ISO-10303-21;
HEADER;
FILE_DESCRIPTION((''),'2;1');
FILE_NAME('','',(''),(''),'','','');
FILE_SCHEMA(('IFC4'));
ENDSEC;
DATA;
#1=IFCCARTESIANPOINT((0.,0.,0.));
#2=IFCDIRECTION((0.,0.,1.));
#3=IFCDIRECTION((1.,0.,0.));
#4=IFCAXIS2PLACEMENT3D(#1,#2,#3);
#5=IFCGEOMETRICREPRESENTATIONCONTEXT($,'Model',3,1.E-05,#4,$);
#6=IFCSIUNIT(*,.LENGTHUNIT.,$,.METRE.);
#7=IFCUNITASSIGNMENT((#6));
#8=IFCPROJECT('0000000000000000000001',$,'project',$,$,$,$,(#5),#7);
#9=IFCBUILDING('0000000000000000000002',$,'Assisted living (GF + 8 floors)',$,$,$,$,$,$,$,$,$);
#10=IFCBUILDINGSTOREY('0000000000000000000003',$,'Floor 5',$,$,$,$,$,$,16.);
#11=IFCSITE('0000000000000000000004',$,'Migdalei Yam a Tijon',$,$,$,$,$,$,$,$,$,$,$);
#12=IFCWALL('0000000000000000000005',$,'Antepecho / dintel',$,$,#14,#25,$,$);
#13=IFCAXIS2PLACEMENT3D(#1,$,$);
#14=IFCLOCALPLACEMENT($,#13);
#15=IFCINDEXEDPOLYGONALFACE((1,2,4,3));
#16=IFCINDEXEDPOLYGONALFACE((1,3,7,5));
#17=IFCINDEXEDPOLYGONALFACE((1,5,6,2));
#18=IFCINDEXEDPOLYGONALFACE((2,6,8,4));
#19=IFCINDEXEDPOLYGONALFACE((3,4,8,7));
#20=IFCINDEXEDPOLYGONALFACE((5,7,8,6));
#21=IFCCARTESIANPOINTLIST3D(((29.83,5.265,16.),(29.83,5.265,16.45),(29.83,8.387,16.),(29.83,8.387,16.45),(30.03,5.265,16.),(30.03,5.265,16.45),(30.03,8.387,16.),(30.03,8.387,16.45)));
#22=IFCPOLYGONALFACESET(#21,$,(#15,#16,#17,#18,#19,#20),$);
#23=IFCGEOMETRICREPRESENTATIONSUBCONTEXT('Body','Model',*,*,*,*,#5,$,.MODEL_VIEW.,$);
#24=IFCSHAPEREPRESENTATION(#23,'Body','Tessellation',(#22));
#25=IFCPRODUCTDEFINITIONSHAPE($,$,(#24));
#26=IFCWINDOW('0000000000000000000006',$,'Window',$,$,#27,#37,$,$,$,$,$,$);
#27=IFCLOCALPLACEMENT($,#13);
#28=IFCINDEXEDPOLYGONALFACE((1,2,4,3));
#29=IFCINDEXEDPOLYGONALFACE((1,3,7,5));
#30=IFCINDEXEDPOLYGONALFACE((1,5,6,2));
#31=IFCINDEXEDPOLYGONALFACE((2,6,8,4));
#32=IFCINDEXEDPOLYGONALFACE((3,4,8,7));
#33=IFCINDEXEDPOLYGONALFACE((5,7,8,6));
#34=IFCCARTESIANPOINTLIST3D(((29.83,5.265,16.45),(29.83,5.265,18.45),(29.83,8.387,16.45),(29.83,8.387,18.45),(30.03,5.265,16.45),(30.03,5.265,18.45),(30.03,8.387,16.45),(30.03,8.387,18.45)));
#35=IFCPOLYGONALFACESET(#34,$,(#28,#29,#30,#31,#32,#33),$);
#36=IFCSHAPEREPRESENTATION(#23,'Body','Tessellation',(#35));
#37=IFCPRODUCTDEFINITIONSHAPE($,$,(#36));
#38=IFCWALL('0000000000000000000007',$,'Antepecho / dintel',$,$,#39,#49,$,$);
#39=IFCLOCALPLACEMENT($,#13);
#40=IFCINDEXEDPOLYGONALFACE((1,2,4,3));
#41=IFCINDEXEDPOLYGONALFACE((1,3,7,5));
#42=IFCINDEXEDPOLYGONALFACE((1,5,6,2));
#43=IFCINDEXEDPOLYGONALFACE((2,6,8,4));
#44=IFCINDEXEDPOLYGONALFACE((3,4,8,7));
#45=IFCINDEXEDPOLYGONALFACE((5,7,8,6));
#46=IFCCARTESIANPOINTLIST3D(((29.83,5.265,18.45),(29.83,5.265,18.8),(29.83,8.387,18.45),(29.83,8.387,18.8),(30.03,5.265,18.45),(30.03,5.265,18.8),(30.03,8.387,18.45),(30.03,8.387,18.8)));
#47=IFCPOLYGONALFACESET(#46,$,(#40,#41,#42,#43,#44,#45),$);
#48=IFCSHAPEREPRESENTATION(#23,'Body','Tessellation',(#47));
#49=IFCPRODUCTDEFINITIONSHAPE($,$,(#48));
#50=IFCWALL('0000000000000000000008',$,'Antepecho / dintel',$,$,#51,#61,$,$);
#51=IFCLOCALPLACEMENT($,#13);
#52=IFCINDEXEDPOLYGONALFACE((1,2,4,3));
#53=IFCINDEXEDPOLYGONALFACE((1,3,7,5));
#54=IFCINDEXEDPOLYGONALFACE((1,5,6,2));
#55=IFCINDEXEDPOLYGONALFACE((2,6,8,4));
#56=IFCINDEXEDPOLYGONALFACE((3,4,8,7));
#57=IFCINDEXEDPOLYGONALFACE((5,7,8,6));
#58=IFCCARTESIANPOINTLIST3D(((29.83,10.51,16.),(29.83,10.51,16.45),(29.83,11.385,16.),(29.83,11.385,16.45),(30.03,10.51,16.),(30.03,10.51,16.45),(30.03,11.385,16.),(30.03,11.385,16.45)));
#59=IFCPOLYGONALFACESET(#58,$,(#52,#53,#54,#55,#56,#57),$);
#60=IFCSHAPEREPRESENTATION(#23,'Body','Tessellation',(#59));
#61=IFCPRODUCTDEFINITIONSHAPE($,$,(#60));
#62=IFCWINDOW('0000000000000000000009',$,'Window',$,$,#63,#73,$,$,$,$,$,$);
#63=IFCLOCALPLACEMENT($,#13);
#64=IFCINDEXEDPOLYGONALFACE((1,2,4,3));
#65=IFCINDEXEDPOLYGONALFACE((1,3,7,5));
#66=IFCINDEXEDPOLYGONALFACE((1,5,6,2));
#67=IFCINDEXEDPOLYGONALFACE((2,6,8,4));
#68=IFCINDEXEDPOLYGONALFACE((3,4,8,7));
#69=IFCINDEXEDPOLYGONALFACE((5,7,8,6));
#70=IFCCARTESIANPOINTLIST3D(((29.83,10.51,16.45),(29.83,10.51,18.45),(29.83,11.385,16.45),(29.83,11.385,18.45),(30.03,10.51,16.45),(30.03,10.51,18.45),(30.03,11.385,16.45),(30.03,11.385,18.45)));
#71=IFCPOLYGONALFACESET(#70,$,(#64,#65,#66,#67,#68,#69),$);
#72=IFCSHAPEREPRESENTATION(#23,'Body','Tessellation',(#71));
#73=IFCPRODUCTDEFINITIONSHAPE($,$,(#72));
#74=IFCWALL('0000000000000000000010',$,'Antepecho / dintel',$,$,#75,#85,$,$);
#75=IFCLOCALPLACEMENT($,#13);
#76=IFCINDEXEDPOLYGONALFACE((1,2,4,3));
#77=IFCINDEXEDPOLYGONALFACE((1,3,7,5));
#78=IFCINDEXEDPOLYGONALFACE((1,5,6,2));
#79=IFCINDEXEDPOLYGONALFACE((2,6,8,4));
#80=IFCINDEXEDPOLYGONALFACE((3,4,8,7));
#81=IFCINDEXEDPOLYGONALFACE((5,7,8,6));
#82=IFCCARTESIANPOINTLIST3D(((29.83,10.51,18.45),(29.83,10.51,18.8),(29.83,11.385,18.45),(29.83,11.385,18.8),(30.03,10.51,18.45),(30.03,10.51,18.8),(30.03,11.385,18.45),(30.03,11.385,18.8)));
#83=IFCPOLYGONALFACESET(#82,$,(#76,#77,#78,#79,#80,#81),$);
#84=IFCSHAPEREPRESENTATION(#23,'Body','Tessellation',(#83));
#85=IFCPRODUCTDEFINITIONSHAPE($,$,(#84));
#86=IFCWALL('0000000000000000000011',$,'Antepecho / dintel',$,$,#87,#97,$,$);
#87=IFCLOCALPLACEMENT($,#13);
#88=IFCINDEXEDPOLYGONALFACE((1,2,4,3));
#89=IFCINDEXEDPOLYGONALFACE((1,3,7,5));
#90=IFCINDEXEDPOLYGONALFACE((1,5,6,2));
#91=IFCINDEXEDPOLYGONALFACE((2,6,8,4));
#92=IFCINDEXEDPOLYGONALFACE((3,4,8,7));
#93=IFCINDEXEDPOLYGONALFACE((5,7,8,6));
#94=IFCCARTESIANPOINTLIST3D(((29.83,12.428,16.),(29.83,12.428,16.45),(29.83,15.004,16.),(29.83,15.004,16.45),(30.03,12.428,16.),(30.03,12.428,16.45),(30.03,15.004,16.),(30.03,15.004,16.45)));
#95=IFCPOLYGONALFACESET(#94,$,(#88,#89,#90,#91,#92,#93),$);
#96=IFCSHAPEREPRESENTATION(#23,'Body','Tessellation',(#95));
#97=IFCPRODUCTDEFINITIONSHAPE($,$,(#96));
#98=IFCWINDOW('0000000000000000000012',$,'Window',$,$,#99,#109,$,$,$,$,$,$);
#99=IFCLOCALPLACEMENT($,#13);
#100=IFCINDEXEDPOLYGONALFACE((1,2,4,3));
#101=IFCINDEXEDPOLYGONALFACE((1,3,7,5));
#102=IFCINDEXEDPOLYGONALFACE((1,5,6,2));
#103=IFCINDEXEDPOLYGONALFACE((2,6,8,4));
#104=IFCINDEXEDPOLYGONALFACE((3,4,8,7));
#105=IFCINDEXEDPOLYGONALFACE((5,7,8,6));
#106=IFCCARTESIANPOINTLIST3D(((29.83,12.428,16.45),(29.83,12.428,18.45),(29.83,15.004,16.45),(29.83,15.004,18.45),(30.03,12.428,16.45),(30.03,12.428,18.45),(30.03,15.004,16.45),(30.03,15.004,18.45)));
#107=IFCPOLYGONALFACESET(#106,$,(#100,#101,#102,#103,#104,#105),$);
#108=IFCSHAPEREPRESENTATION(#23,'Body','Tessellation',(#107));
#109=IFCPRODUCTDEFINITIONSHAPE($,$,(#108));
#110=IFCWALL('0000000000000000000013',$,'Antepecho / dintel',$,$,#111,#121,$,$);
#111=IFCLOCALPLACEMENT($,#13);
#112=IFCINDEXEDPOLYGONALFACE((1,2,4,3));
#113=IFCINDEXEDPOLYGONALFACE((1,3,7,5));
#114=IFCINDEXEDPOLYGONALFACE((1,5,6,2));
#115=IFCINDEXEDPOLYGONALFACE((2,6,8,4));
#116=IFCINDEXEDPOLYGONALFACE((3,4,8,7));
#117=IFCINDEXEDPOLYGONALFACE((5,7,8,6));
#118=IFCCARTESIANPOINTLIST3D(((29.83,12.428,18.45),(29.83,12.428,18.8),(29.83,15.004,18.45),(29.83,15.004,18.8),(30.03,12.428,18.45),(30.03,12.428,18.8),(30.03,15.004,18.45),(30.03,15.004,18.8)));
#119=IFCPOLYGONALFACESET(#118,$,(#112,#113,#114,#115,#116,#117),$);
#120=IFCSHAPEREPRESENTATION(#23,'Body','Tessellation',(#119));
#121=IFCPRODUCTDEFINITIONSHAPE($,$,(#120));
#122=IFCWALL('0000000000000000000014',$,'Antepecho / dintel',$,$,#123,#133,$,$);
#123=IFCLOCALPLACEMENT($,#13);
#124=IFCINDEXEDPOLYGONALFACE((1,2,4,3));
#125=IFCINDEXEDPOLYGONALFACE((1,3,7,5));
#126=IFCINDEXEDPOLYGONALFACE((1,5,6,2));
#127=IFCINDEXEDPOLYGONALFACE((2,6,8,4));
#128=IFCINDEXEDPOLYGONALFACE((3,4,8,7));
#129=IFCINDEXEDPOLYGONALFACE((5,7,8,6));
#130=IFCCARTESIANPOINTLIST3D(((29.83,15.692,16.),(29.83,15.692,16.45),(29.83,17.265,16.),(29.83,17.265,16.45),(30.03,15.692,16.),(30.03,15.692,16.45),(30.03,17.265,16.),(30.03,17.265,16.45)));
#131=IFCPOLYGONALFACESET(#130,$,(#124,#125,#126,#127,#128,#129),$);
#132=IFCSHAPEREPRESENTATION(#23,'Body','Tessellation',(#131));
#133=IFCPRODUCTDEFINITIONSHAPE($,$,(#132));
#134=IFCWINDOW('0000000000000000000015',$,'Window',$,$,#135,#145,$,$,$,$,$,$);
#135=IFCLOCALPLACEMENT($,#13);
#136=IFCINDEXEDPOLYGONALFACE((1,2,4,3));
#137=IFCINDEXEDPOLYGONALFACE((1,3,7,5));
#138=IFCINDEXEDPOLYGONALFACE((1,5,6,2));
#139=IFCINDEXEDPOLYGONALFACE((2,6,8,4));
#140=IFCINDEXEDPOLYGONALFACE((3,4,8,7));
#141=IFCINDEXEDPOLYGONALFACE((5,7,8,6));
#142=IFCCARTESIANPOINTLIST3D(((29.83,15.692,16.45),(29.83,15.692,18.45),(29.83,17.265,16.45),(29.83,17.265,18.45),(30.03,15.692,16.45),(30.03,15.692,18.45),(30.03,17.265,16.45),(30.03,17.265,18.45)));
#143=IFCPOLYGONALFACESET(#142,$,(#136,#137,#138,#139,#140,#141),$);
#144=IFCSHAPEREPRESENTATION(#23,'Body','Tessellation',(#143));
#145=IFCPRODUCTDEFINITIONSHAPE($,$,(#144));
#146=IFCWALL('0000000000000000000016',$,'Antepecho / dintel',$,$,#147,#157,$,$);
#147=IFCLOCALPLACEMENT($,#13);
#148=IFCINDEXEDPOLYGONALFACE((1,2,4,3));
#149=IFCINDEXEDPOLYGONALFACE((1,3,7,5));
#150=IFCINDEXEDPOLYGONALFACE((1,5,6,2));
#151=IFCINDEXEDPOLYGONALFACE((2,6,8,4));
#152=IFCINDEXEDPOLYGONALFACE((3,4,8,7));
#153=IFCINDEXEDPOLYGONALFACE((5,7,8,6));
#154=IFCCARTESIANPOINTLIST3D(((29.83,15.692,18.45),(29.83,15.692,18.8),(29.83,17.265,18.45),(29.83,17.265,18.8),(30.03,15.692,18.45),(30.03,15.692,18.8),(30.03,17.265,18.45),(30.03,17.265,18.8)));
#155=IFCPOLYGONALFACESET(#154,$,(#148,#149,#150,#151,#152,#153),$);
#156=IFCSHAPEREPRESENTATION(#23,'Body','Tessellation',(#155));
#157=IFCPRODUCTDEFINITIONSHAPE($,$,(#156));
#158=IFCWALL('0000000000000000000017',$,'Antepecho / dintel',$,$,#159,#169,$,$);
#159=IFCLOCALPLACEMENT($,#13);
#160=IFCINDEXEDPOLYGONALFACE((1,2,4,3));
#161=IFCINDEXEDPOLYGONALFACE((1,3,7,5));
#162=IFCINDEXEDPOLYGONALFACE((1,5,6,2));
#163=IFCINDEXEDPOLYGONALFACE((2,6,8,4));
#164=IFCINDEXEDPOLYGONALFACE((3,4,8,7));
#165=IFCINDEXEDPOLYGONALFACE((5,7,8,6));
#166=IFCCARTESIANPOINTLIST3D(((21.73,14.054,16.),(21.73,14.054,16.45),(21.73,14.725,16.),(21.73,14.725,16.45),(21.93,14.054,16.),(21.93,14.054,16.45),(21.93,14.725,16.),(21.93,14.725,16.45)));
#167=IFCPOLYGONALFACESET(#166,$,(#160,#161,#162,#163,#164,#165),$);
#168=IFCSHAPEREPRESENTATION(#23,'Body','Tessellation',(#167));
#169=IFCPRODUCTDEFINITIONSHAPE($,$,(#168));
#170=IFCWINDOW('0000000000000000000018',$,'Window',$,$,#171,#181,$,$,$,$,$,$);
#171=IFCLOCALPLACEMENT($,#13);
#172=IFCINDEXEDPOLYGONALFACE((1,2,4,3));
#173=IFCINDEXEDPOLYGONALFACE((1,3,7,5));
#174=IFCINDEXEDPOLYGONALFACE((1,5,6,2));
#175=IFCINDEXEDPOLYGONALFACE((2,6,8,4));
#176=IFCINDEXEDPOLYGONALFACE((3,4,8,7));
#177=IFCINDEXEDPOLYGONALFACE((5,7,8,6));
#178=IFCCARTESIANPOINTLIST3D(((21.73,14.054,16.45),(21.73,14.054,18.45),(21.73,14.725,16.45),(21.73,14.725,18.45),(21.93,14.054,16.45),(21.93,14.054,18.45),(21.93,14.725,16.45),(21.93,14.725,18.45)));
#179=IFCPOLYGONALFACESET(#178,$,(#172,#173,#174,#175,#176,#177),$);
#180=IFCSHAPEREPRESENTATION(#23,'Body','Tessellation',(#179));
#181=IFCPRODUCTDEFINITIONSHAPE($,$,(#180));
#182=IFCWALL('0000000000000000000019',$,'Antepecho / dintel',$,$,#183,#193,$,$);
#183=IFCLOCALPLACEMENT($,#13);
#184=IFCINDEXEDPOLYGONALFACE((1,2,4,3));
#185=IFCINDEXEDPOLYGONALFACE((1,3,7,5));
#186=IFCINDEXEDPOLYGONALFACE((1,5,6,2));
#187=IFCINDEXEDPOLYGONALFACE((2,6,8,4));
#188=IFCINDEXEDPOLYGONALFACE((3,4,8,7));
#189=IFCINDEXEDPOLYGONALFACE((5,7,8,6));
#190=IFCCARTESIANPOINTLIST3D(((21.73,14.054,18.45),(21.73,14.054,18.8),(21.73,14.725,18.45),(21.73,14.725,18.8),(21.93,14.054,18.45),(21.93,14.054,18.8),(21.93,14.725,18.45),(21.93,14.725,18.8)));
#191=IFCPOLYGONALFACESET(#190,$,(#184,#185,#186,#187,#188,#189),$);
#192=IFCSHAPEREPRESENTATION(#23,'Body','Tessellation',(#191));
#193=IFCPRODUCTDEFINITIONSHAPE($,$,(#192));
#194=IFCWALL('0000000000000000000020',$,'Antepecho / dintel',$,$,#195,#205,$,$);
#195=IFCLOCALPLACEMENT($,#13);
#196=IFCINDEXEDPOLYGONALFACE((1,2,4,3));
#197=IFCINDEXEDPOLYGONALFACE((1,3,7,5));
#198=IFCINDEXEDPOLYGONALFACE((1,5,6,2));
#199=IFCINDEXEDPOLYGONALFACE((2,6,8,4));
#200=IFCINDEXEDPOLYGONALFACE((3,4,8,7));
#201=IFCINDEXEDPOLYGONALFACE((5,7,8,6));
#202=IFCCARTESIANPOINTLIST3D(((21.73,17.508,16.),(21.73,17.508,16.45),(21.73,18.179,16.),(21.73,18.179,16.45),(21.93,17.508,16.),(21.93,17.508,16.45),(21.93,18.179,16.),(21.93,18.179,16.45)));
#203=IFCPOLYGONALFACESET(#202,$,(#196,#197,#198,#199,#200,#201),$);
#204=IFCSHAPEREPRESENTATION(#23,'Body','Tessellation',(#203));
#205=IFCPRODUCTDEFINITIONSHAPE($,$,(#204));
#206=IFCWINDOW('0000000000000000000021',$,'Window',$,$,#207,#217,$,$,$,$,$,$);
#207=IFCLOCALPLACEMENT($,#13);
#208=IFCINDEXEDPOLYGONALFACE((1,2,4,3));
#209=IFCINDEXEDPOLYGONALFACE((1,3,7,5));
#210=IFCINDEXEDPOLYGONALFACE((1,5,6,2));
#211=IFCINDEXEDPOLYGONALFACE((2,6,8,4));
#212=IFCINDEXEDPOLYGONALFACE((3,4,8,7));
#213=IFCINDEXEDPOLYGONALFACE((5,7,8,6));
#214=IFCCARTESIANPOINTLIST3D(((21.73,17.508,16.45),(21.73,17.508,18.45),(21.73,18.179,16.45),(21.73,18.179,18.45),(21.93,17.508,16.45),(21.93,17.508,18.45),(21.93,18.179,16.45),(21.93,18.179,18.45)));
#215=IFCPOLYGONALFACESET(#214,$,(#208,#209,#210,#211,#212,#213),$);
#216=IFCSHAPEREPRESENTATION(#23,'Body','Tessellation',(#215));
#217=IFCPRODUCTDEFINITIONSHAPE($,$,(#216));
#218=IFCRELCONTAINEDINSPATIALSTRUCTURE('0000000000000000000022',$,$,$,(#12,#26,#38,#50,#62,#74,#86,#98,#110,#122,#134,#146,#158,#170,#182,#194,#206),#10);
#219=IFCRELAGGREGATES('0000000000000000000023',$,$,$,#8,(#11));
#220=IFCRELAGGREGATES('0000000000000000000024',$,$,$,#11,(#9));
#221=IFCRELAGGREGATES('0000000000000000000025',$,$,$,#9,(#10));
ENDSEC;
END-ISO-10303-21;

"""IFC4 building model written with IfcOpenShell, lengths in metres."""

from ifc_helpers import new_model, si_unit, frame, origin_with_axes, context, subcontext, project, spatial, line, indexed_curve, outline, extrude, element, save


model = new_model("IFC4")

# Units and contexts
model_context = context("Model", 3, precision=1e-05, world=origin_with_axes())
body_context = subcontext(model_context, "Body", "Model", "MODEL_VIEW")
ifc_project = project(units=[si_unit("LENGTHUNIT", "METRE")], contexts=[model_context])

# Site, building, storey
site = spatial("IfcSite", under=ifc_project, Name="Migdalei Yam a Tijon")
building = spatial("IfcBuilding", under=site, Name="Assisted living (GF + 8 floors)")
storey = spatial("IfcBuildingStorey", under=building, Name="Floor 5", Elevation=16.0)

# Wall
element("IfcWall", 1, inside=storey, Name="Antepecho / dintel", context=body_context, shape_type="SweptSolid", body=[
    extrude(outline(indexed_curve([(0.0, 0.0), (0.2, 0.0), (0.2, 3.122), (0.0, 3.122)], segments=[line(1, 2, 3, 4, 1)])), frame((29.83, 5.265, 16.0), z_axis=(0.0, 0.0, 1.0), x_axis=(1.0, 0.0, 0.0)), (0.0, 0.0, 1.0), 0.45),
])

# Window
element("IfcWindow", 2, inside=storey, Name="Window", context=body_context, shape_type="SweptSolid", body=[
    extrude(outline(indexed_curve([(0.0, 0.0), (0.2, 0.0), (0.2, 3.122), (0.0, 3.122)], segments=[line(1, 2, 3, 4, 1)])), frame((29.83, 5.265, 16.45), z_axis=(0.0, 0.0, 1.0), x_axis=(1.0, 0.0, 0.0)), (0.0, 0.0, 1.0), 2.0),
])

# Walls
element("IfcWall", 3, inside=storey, Name="Antepecho / dintel", context=body_context, shape_type="SweptSolid", body=[
    extrude(outline(indexed_curve([(0.0, 0.0), (0.2, 0.0), (0.2, 3.122), (0.0, 3.122)], segments=[line(1, 2, 3, 4, 1)])), frame((29.83, 5.265, 18.45), z_axis=(0.0, 0.0, 1.0), x_axis=(1.0, 0.0, 0.0)), (0.0, 0.0, 1.0), 0.35),
])
element("IfcWall", 4, inside=storey, Name="Antepecho / dintel", context=body_context, shape_type="SweptSolid", body=[
    extrude(outline(indexed_curve([(0.0, 0.0), (0.2, 0.0), (0.2, 0.875), (0.0, 0.875)], segments=[line(1, 2, 3, 4, 1)])), frame((29.83, 10.51, 16.0), z_axis=(0.0, 0.0, 1.0), x_axis=(1.0, 0.0, 0.0)), (0.0, 0.0, 1.0), 0.45),
])

# Window
element("IfcWindow", 5, inside=storey, Name="Window", context=body_context, shape_type="SweptSolid", body=[
    extrude(outline(indexed_curve([(0.0, 0.0), (0.2, 0.0), (0.2, 0.875), (0.0, 0.875)], segments=[line(1, 2, 3, 4, 1)])), frame((29.83, 10.51, 16.45), z_axis=(0.0, 0.0, 1.0), x_axis=(1.0, 0.0, 0.0)), (0.0, 0.0, 1.0), 2.0),
])

# Walls
element("IfcWall", 6, inside=storey, Name="Antepecho / dintel", context=body_context, shape_type="SweptSolid", body=[
    extrude(outline(indexed_curve([(0.0, 0.0), (0.2, 0.0), (0.2, 0.875), (0.0, 0.875)], segments=[line(1, 2, 3, 4, 1)])), frame((29.83, 10.51, 18.45), z_axis=(0.0, 0.0, 1.0), x_axis=(1.0, 0.0, 0.0)), (0.0, 0.0, 1.0), 0.35),
])
element("IfcWall", 7, inside=storey, Name="Antepecho / dintel", context=body_context, shape_type="SweptSolid", body=[
    extrude(outline(indexed_curve([(0.0, 0.0), (0.2, 0.0), (0.2, 2.576), (0.0, 2.576)], segments=[line(1, 2, 3, 4, 1)])), frame((29.83, 12.428, 16.0), z_axis=(0.0, 0.0, 1.0), x_axis=(1.0, 0.0, 0.0)), (0.0, 0.0, 1.0), 0.45),
])

# Window
element("IfcWindow", 8, inside=storey, Name="Window", context=body_context, shape_type="SweptSolid", body=[
    extrude(outline(indexed_curve([(0.0, 0.0), (0.2, 0.0), (0.2, 2.576), (0.0, 2.576)], segments=[line(1, 2, 3, 4, 1)])), frame((29.83, 12.428, 16.45), z_axis=(0.0, 0.0, 1.0), x_axis=(1.0, 0.0, 0.0)), (0.0, 0.0, 1.0), 2.0),
])

# Walls
element("IfcWall", 9, inside=storey, Name="Antepecho / dintel", context=body_context, shape_type="SweptSolid", body=[
    extrude(outline(indexed_curve([(0.0, 0.0), (0.2, 0.0), (0.2, 2.576), (0.0, 2.576)], segments=[line(1, 2, 3, 4, 1)])), frame((29.83, 12.428, 18.45), z_axis=(0.0, 0.0, 1.0), x_axis=(1.0, 0.0, 0.0)), (0.0, 0.0, 1.0), 0.35),
])
element("IfcWall", 10, inside=storey, Name="Antepecho / dintel", context=body_context, shape_type="SweptSolid", body=[
    extrude(outline(indexed_curve([(0.0, 0.0), (0.2, 0.0), (0.2, 1.573), (0.0, 1.573)], segments=[line(1, 2, 3, 4, 1)])), frame((29.83, 15.692, 16.0), z_axis=(0.0, 0.0, 1.0), x_axis=(1.0, 0.0, 0.0)), (0.0, 0.0, 1.0), 0.45),
])

# Window
element("IfcWindow", 11, inside=storey, Name="Window", context=body_context, shape_type="SweptSolid", body=[
    extrude(outline(indexed_curve([(0.0, 0.0), (0.2, 0.0), (0.2, 1.573), (0.0, 1.573)], segments=[line(1, 2, 3, 4, 1)])), frame((29.83, 15.692, 16.45), z_axis=(0.0, 0.0, 1.0), x_axis=(1.0, 0.0, 0.0)), (0.0, 0.0, 1.0), 2.0),
])

# Walls
element("IfcWall", 12, inside=storey, Name="Antepecho / dintel", context=body_context, shape_type="SweptSolid", body=[
    extrude(outline(indexed_curve([(0.0, 0.0), (0.2, 0.0), (0.2, 1.573), (0.0, 1.573)], segments=[line(1, 2, 3, 4, 1)])), frame((29.83, 15.692, 18.45), z_axis=(0.0, 0.0, 1.0), x_axis=(1.0, 0.0, 0.0)), (0.0, 0.0, 1.0), 0.35),
])
element("IfcWall", 13, inside=storey, Name="Antepecho / dintel", context=body_context, shape_type="SweptSolid", body=[
    extrude(outline(indexed_curve([(0.0, 0.0), (0.2, 0.0), (0.2, 0.671), (0.0, 0.671)], segments=[line(1, 2, 3, 4, 1)])), frame((21.73, 14.054, 16.0), z_axis=(0.0, 0.0, 1.0), x_axis=(1.0, 0.0, 0.0)), (0.0, 0.0, 1.0), 0.45),
])

# Window
element("IfcWindow", 14, inside=storey, Name="Window", context=body_context, shape_type="SweptSolid", body=[
    extrude(outline(indexed_curve([(0.0, 0.0), (0.2, 0.0), (0.2, 0.671), (0.0, 0.671)], segments=[line(1, 2, 3, 4, 1)])), frame((21.73, 14.054, 16.45), z_axis=(0.0, 0.0, 1.0), x_axis=(1.0, 0.0, 0.0)), (0.0, 0.0, 1.0), 2.0),
])

# Walls
element("IfcWall", 15, inside=storey, Name="Antepecho / dintel", context=body_context, shape_type="SweptSolid", body=[
    extrude(outline(indexed_curve([(0.0, 0.0), (0.2, 0.0), (0.2, 0.671), (0.0, 0.671)], segments=[line(1, 2, 3, 4, 1)])), frame((21.73, 14.054, 18.45), z_axis=(0.0, 0.0, 1.0), x_axis=(1.0, 0.0, 0.0)), (0.0, 0.0, 1.0), 0.35),
])
element("IfcWall", 16, inside=storey, Name="Antepecho / dintel", context=body_context, shape_type="SweptSolid", body=[
    extrude(outline(indexed_curve([(0.0, 0.0), (0.2, 0.0), (0.2, 0.671), (0.0, 0.671)], segments=[line(1, 2, 3, 4, 1)])), frame((21.73, 17.508, 16.0), z_axis=(0.0, 0.0, 1.0), x_axis=(1.0, 0.0, 0.0)), (0.0, 0.0, 1.0), 0.45),
])

# Window
element("IfcWindow", 17, inside=storey, Name="Window", context=body_context, shape_type="SweptSolid", body=[
    extrude(outline(indexed_curve([(0.0, 0.0), (0.2, 0.0), (0.2, 0.671), (0.0, 0.671)], segments=[line(1, 2, 3, 4, 1)])), frame((21.73, 17.508, 16.45), z_axis=(0.0, 0.0, 1.0), x_axis=(1.0, 0.0, 0.0)), (0.0, 0.0, 1.0), 2.0),
])

save(model, "model.ifc")
